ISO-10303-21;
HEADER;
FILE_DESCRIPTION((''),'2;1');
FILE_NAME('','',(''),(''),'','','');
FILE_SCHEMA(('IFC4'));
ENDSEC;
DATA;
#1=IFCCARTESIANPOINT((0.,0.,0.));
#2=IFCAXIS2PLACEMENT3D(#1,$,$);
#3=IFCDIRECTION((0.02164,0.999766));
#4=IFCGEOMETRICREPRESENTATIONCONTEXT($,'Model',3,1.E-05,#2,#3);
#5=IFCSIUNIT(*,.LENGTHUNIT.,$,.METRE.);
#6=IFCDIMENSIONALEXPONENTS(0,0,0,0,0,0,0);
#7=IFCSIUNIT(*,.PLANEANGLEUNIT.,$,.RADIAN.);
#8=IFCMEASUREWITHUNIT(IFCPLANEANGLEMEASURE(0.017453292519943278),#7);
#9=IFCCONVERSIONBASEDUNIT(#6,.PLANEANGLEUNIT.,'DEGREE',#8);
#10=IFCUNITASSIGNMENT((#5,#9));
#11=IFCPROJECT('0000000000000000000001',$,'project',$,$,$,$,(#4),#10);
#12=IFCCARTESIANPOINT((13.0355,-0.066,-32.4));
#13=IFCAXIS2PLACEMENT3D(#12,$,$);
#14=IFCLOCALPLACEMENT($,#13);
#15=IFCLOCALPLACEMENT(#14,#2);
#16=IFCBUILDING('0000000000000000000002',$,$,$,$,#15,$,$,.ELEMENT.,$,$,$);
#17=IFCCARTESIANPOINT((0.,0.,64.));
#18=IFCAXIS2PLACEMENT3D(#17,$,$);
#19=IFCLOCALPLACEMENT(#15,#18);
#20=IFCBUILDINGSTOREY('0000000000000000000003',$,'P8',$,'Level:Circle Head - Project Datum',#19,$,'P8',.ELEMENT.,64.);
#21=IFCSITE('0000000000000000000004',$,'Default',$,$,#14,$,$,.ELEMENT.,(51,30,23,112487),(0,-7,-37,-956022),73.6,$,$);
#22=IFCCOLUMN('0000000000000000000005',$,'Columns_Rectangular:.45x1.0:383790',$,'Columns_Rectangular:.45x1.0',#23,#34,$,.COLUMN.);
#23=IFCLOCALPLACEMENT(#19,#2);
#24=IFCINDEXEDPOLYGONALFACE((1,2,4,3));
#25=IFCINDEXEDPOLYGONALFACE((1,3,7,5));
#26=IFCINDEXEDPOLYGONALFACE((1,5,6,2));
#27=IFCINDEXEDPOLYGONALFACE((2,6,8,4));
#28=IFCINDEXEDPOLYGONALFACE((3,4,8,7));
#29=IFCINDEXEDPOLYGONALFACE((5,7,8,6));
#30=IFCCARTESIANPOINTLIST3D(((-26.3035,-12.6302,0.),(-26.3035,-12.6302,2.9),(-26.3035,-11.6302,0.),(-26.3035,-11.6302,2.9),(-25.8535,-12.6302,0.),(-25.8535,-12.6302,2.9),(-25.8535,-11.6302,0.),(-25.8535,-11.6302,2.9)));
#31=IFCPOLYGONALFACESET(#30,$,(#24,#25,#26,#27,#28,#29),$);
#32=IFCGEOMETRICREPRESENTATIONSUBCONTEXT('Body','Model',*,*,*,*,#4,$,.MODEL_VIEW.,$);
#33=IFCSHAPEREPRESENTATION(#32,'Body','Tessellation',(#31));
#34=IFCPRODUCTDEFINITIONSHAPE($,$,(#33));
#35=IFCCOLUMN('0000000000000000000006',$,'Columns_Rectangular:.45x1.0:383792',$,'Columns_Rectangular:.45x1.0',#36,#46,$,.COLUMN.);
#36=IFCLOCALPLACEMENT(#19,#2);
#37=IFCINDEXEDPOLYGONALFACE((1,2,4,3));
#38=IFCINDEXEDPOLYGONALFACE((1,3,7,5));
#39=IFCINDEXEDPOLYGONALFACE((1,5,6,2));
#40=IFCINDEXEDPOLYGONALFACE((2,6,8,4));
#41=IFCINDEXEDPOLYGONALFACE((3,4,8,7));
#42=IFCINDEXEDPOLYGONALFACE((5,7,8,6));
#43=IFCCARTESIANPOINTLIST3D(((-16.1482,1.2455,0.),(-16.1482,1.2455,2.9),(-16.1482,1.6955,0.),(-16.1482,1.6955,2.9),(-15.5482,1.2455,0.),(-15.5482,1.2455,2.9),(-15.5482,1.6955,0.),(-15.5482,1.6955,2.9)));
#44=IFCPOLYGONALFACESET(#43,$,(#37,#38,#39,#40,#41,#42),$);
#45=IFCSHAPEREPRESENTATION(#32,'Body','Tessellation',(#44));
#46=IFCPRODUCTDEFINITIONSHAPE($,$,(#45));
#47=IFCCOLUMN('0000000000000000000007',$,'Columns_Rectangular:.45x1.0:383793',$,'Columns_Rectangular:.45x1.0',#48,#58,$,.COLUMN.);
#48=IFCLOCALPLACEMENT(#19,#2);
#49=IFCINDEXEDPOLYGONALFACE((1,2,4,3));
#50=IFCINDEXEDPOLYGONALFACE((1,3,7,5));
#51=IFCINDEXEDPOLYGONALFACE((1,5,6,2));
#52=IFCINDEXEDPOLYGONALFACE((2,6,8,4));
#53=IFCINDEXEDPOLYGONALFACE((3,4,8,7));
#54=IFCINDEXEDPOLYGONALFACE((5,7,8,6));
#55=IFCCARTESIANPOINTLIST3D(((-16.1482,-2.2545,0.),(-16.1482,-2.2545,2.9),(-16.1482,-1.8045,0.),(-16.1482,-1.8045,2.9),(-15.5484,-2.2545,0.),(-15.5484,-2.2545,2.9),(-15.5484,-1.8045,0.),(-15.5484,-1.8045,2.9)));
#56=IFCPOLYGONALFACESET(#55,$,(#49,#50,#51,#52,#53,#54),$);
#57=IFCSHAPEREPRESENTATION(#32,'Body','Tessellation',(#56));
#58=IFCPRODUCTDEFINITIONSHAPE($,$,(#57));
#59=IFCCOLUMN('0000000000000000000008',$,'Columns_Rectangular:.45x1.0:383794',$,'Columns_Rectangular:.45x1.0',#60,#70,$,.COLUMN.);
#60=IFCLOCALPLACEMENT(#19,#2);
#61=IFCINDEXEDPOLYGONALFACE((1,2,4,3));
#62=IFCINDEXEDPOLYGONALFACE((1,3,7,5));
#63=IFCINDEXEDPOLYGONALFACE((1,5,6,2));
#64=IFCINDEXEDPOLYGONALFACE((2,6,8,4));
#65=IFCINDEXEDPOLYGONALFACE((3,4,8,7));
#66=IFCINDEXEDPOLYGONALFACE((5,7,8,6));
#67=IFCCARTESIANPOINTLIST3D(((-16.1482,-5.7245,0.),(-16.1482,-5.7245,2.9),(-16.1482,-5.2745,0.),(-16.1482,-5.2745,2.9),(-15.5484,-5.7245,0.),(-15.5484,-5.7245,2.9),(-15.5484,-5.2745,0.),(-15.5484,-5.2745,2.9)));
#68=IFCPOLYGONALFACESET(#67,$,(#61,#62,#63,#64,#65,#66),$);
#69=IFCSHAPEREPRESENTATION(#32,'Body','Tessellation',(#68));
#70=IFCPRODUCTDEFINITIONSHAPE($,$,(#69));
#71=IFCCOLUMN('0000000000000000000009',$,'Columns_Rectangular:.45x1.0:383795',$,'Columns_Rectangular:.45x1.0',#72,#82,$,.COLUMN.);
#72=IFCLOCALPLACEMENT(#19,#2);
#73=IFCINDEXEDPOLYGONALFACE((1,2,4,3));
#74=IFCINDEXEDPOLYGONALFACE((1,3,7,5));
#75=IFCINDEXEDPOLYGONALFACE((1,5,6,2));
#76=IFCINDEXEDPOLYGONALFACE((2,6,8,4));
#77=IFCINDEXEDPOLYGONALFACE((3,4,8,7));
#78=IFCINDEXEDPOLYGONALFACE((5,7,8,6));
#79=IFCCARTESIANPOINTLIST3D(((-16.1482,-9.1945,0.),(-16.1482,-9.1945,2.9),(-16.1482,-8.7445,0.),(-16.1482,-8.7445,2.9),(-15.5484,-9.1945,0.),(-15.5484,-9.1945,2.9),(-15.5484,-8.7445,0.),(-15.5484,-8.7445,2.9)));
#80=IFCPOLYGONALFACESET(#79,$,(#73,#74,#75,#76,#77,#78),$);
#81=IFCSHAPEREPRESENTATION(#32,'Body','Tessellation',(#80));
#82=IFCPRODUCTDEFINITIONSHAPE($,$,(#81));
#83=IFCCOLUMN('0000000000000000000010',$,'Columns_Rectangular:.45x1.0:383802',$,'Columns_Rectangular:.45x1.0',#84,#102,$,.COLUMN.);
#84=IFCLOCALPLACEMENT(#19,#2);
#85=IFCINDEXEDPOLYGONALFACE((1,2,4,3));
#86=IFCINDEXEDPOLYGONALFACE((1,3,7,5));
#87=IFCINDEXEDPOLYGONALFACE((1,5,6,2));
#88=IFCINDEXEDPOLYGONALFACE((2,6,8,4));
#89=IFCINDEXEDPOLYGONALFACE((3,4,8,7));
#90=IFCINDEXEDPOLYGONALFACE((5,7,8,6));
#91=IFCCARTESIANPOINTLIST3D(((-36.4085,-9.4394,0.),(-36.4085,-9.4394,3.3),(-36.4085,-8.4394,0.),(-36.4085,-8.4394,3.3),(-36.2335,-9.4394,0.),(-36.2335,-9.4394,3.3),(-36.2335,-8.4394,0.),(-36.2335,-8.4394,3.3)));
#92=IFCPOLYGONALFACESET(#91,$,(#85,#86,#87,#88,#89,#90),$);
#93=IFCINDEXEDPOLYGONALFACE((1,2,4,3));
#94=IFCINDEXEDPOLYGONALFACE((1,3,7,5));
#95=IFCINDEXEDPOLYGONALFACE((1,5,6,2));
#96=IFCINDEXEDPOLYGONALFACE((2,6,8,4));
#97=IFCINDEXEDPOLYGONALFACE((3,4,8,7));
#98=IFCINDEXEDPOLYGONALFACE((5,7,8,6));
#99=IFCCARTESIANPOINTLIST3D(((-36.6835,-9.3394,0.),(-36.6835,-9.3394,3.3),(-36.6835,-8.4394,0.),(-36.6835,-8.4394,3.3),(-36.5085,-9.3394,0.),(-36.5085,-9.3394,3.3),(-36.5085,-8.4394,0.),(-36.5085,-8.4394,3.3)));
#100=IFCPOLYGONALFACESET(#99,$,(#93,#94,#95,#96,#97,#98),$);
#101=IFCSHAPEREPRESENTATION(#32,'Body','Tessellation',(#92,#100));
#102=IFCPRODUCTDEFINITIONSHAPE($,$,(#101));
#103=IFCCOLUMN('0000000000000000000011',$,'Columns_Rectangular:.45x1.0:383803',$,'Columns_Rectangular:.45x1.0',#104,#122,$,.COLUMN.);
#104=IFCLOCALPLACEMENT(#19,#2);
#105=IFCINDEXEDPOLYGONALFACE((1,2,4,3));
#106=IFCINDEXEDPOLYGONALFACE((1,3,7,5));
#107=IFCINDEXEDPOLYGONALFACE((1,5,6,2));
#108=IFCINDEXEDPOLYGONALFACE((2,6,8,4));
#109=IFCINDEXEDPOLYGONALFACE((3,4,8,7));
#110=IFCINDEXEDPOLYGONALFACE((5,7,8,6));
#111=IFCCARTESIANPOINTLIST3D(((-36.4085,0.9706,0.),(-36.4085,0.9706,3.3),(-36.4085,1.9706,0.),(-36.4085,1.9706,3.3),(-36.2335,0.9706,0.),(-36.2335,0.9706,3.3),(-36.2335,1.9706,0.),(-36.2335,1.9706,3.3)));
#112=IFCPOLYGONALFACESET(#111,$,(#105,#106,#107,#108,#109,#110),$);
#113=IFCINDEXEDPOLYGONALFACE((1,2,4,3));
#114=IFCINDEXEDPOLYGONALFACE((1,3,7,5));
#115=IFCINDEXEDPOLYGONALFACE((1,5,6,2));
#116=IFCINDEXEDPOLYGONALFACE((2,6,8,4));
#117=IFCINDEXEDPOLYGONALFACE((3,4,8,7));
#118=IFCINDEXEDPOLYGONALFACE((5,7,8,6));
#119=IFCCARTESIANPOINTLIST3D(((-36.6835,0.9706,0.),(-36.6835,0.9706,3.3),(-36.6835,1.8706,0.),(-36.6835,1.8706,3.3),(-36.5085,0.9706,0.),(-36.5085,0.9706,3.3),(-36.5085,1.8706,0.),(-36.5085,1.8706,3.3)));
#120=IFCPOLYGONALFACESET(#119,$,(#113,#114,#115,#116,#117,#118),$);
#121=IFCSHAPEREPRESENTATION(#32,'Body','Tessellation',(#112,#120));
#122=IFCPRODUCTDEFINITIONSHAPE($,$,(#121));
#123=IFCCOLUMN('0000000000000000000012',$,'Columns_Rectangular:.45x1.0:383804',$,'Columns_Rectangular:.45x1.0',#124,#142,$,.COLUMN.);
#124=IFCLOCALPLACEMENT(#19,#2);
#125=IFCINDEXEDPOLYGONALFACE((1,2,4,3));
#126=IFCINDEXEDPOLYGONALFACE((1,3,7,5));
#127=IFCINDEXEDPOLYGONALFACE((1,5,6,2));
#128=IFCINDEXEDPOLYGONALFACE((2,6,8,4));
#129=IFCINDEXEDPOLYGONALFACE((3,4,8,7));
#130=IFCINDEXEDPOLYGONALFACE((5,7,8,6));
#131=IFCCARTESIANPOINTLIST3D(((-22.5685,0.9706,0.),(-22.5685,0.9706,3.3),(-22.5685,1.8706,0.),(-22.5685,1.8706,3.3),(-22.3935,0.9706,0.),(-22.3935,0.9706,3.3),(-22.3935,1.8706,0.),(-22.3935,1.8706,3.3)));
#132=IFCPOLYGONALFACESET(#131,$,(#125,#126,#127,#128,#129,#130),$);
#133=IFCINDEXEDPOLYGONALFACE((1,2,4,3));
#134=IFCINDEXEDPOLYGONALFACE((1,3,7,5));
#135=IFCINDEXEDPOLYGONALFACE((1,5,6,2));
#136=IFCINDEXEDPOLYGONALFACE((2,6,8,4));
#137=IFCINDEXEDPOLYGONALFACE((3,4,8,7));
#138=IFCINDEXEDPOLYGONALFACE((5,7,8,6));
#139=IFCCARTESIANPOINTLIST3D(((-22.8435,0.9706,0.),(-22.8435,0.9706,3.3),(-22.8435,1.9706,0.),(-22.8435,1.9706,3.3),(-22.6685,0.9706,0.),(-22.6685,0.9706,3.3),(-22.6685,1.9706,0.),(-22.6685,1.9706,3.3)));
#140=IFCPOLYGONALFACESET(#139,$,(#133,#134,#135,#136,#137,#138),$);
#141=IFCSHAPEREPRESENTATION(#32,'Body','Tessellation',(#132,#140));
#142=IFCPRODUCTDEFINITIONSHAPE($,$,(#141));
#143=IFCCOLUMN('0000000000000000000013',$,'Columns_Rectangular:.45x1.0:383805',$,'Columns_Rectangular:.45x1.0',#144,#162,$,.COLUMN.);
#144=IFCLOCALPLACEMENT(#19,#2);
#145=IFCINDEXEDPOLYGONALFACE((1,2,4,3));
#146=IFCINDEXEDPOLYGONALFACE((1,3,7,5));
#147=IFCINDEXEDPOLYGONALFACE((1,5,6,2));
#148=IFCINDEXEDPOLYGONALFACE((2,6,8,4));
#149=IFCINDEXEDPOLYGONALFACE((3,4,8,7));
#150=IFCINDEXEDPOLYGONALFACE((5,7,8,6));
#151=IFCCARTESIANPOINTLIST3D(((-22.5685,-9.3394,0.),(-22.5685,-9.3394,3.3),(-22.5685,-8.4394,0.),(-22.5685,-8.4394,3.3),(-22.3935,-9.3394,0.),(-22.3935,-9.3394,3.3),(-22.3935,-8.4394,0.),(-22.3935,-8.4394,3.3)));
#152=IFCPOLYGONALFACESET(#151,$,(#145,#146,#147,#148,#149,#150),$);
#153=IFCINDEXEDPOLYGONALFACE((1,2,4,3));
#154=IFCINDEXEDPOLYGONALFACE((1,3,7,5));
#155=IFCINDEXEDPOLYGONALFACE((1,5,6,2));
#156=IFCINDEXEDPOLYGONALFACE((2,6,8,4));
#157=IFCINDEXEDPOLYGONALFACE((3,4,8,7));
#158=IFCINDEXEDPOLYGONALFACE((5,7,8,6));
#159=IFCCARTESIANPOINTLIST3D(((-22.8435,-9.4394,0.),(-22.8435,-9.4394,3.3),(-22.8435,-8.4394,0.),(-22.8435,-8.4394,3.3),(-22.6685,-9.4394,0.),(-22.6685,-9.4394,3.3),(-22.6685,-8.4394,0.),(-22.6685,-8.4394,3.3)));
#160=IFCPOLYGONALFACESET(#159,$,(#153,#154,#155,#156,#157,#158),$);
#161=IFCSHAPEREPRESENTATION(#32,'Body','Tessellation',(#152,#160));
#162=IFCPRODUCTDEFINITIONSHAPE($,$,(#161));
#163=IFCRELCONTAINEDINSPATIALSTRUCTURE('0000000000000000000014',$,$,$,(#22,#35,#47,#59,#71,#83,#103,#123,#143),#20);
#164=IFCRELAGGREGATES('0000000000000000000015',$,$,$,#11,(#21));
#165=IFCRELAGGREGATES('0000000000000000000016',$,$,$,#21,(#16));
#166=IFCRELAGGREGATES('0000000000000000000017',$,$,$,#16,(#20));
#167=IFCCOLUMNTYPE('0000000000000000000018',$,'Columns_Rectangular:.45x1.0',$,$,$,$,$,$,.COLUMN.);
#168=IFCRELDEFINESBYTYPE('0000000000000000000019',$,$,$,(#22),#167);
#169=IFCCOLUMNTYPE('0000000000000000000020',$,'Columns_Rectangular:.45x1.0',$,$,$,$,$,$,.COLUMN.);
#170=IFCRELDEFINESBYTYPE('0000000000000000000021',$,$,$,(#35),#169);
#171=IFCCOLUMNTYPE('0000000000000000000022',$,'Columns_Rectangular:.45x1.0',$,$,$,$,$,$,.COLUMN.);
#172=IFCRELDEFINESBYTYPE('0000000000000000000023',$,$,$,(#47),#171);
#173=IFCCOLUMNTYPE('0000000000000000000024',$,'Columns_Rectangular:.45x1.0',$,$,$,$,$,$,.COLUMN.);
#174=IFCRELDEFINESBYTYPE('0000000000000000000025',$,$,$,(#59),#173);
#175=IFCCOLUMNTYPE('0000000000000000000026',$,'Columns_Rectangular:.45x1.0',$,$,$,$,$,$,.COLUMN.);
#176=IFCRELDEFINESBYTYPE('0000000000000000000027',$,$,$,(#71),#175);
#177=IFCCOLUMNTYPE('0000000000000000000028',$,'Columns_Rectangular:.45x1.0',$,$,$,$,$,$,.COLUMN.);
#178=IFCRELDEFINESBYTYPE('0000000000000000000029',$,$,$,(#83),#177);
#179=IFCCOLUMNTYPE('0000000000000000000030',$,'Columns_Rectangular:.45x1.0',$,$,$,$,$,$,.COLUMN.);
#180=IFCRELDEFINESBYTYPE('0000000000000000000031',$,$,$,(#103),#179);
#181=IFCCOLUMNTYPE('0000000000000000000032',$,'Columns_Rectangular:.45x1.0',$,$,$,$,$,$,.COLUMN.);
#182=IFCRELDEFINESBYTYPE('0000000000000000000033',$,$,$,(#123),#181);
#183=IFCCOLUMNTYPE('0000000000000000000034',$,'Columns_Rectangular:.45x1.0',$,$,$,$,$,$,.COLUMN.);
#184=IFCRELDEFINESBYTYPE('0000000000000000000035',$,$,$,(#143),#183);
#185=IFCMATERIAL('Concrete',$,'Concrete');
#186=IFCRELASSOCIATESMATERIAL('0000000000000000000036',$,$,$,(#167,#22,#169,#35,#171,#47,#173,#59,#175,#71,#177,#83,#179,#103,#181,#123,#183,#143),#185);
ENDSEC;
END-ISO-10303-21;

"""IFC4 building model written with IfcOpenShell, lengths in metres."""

from ifc_helpers import new_model, entity, si_unit, converted_unit, direction, frame, origin, place, context, subcontext, project, spatial, indexed_curve, outline, extrude, source, transform, mapped, material, type_object, type_shapes, element, save


model = new_model("IFC4")

# Units and contexts
model_context = context("Model", 3, precision=1e-05, world=origin(), true_north=direction((0.02164, 0.999766)))
body_context = subcontext(model_context, "Body", "Model", "MODEL_VIEW")
ifc_project = project(units=[si_unit("LENGTHUNIT", "METRE"), converted_unit("PLANEANGLEUNIT", "DEGREE", entity("IfcPlaneAngleMeasure", 0.017453292519943278), si_unit("PLANEANGLEUNIT", "RADIAN"), dimensions=[0, 0, 0, 0, 0, 0, 0])], contexts=[model_context])

# Site, building, storey
site_placement = place(None, frame((13.0355, -0.066, -32.4)))
site = spatial("IfcSite", under=ifc_project, at=site_placement, Name="Default", CompositionType="ELEMENT", RefLatitude=(51, 30, 23, 112487), RefLongitude=(0, -7, -37, -956022), RefElevation=73.6)
building_placement = place(site_placement, origin())
building = spatial("IfcBuilding", under=site, at=building_placement, CompositionType="ELEMENT")
storey_placement = place(building_placement, frame((0.0, 0.0, 64.0)))
storey = spatial("IfcBuildingStorey", under=building, at=storey_placement, Name="P8", ObjectType="Level:Circle Head - Project Datum", LongName="P8", CompositionType="ELEMENT", Elevation=64.0)

# Columns
ifc_material = material(Name="Concrete", Category="Concrete")
column_type_1 = type_object("IfcColumnType", Name="Columns_Rectangular:.45x1.0", PredefinedType="COLUMN", material=ifc_material)
shared_shape_1 = source(origin(), body_context, "Body", "SweptSolid", [
    extrude(outline(indexed_curve([(-0.5, -0.225), (0.5, -0.225), (0.5, 0.225), (-0.5, 0.225), (-0.5, -0.225)], self_intersect=False)), frame((-26.0785, -12.1302, 64.0), z_axis=(0.0, 0.0, 1.0), x_axis=(0.000011, 1.0, 0.0)), (0.0, 0.0, 1.0), 2.9),
])
type_shapes(column_type_1, [shared_shape_1])
column_1_placement = place(storey_placement, frame((0.0, 0.0, -64.0)))
element("IfcColumn", 1, at=column_1_placement, inside=storey, type_object=column_type_1, material=ifc_material, Name="Columns_Rectangular:.45x1.0:383790", ObjectType="Columns_Rectangular:.45x1.0", PredefinedType="COLUMN", context=body_context, shape_type="MappedRepresentation", body=[
    mapped(shared_shape_1, transform((0.0, 0.0, 0.0), scale=1.0)),
])
column_type_2 = type_object("IfcColumnType", Name="Columns_Rectangular:.45x1.0", PredefinedType="COLUMN", material=ifc_material)
shared_shape_2 = source(origin(), body_context, "Body", "SweptSolid", [
    extrude(outline(indexed_curve([(-0.3, -0.225), (0.3, -0.225), (0.3, 0.225), (-0.3, 0.225), (-0.3, -0.225)], self_intersect=False)), frame((-15.8482, 1.4705, 64.0), z_axis=(0.0, 0.0, 1.0), x_axis=(-1.0, 0.0, 0.0)), (0.0, 0.0, 1.0), 2.9),
])
type_shapes(column_type_2, [shared_shape_2])
column_2_placement = place(storey_placement, frame((0.0, 0.0, -64.0)))
element("IfcColumn", 2, at=column_2_placement, inside=storey, type_object=column_type_2, material=ifc_material, Name="Columns_Rectangular:.45x1.0:383792", ObjectType="Columns_Rectangular:.45x1.0", PredefinedType="COLUMN", context=body_context, shape_type="MappedRepresentation", body=[
    mapped(shared_shape_2, transform((0.0, 0.0, 0.0), scale=1.0)),
])
column_type_3 = type_object("IfcColumnType", Name="Columns_Rectangular:.45x1.0", PredefinedType="COLUMN", material=ifc_material)
shared_shape_3 = source(origin(), body_context, "Body", "SweptSolid", [
    extrude(outline(indexed_curve([(-0.2999, -0.225), (0.2999, -0.225), (0.2999, 0.225), (-0.2999, 0.225), (-0.2999, -0.225)], self_intersect=False)), frame((-15.8483, -2.0295, 64.0), z_axis=(0.0, 0.0, 1.0), x_axis=(-1.0, 0.0, 0.0)), (0.0, 0.0, 1.0), 2.9),
])
type_shapes(column_type_3, [shared_shape_3])
column_3_placement = place(storey_placement, frame((0.0, 0.0, -64.0)))
element("IfcColumn", 3, at=column_3_placement, inside=storey, type_object=column_type_3, material=ifc_material, Name="Columns_Rectangular:.45x1.0:383793", ObjectType="Columns_Rectangular:.45x1.0", PredefinedType="COLUMN", context=body_context, shape_type="MappedRepresentation", body=[
    mapped(shared_shape_3, transform((0.0, 0.0, 0.0), scale=1.0)),
])
column_type_4 = type_object("IfcColumnType", Name="Columns_Rectangular:.45x1.0", PredefinedType="COLUMN", material=ifc_material)
shared_shape_4 = source(origin(), body_context, "Body", "SweptSolid", [
    extrude(outline(indexed_curve([(-0.2999, -0.225), (0.2999, -0.225), (0.2999, 0.225), (-0.2999, 0.225), (-0.2999, -0.225)], self_intersect=False)), frame((-15.8483, -5.4995, 64.0), z_axis=(0.0, 0.0, 1.0), x_axis=(-1.0, 0.0, 0.0)), (0.0, 0.0, 1.0), 2.9),
])
type_shapes(column_type_4, [shared_shape_4])
column_4_placement = place(storey_placement, frame((0.0, 0.0, -64.0)))
element("IfcColumn", 4, at=column_4_placement, inside=storey, type_object=column_type_4, material=ifc_material, Name="Columns_Rectangular:.45x1.0:383794", ObjectType="Columns_Rectangular:.45x1.0", PredefinedType="COLUMN", context=body_context, shape_type="MappedRepresentation", body=[
    mapped(shared_shape_4, transform((0.0, 0.0, 0.0), scale=1.0)),
])
column_type_5 = type_object("IfcColumnType", Name="Columns_Rectangular:.45x1.0", PredefinedType="COLUMN", material=ifc_material)
shared_shape_5 = source(origin(), body_context, "Body", "SweptSolid", [
    extrude(outline(indexed_curve([(-0.2999, -0.225), (0.2999, -0.225), (0.2999, 0.225), (-0.2999, 0.225), (-0.2999, -0.225)], self_intersect=False)), frame((-15.8483, -8.9695, 64.0), z_axis=(0.0, 0.0, 1.0), x_axis=(-1.0, 0.0, 0.0)), (0.0, 0.0, 1.0), 2.9),
])
type_shapes(column_type_5, [shared_shape_5])
column_5_placement = place(storey_placement, frame((0.0, 0.0, -64.0)))
element("IfcColumn", 5, at=column_5_placement, inside=storey, type_object=column_type_5, material=ifc_material, Name="Columns_Rectangular:.45x1.0:383795", ObjectType="Columns_Rectangular:.45x1.0", PredefinedType="COLUMN", context=body_context, shape_type="MappedRepresentation", body=[
    mapped(shared_shape_5, transform((0.0, 0.0, 0.0), scale=1.0)),
])
column_type_6 = type_object("IfcColumnType", Name="Columns_Rectangular:.45x1.0", PredefinedType="COLUMN", material=ifc_material)
shared_shape_6 = source(origin(), body_context, "Body", "SweptSolid", [
    extrude(outline(indexed_curve([(-0.0875, -0.5), (0.0875, -0.5), (0.0875, 0.5), (-0.0875, 0.5), (-0.0875, -0.5)], self_intersect=False)), frame((-36.321, -8.9394, 64.0), z_axis=(0.0, 0.0, 1.0), x_axis=(-1.0, 0.0, 0.0)), (0.0, 0.0, 1.0), 3.3),
    extrude(outline(indexed_curve([(-0.45, -0.0875), (0.45, -0.0875), (0.45, 0.0875), (-0.45, 0.0875), (-0.45, -0.0875)], self_intersect=False)), frame((-36.596, -8.8894, 64.0), z_axis=(0.0, 0.0, 1.0), x_axis=(0.0, -1.0, 0.0)), (0.0, 0.0, 1.0), 3.3),
])
type_shapes(column_type_6, [shared_shape_6])
column_6_placement = place(storey_placement, frame((0.0, 0.0, -64.0)))
element("IfcColumn", 6, at=column_6_placement, inside=storey, type_object=column_type_6, material=ifc_material, Name="Columns_Rectangular:.45x1.0:383802", ObjectType="Columns_Rectangular:.45x1.0", PredefinedType="COLUMN", context=body_context, shape_type="MappedRepresentation", body=[
    mapped(shared_shape_6, transform((0.0, 0.0, 0.0), scale=1.0)),
])
column_type_7 = type_object("IfcColumnType", Name="Columns_Rectangular:.45x1.0", PredefinedType="COLUMN", material=ifc_material)
shared_shape_7 = source(origin(), body_context, "Body", "SweptSolid", [
    extrude(outline(indexed_curve([(-0.0875, -0.5), (0.0875, -0.5), (0.0875, 0.5), (-0.0875, 0.5), (-0.0875, -0.5)], self_intersect=False)), frame((-36.321, 1.4706, 64.0), z_axis=(0.0, 0.0, 1.0), x_axis=(-1.0, 0.0, 0.0)), (0.0, 0.0, 1.0), 3.3),
    extrude(outline(indexed_curve([(-0.45, -0.0875), (0.45, -0.0875), (0.45, 0.0875), (-0.45, 0.0875), (-0.45, -0.0875)], self_intersect=False)), frame((-36.596, 1.4206, 64.0), z_axis=(0.0, 0.0, 1.0), x_axis=(0.0, 1.0, 0.0)), (0.0, 0.0, 1.0), 3.3),
])
type_shapes(column_type_7, [shared_shape_7])
column_7_placement = place(storey_placement, frame((0.0, 0.0, -64.0)))
element("IfcColumn", 7, at=column_7_placement, inside=storey, type_object=column_type_7, material=ifc_material, Name="Columns_Rectangular:.45x1.0:383803", ObjectType="Columns_Rectangular:.45x1.0", PredefinedType="COLUMN", context=body_context, shape_type="MappedRepresentation", body=[
    mapped(shared_shape_7, transform((0.0, 0.0, 0.0), scale=1.0)),
])
column_type_8 = type_object("IfcColumnType", Name="Columns_Rectangular:.45x1.0", PredefinedType="COLUMN", material=ifc_material)
shared_shape_8 = source(origin(), body_context, "Body", "SweptSolid", [
    extrude(outline(indexed_curve([(-0.45, -0.0875), (0.45, -0.0875), (0.45, 0.0875), (-0.45, 0.0875), (-0.45, -0.0875)], self_intersect=False)), frame((-22.481, 1.4206, 64.0), z_axis=(0.0, 0.0, 1.0), x_axis=(0.0, 1.0, 0.0)), (0.0, 0.0, 1.0), 3.3),
    extrude(outline(indexed_curve([(-0.0875, -0.5), (0.0875, -0.5), (0.0875, 0.5), (-0.0875, 0.5), (-0.0875, -0.5)], self_intersect=False)), frame((-22.756, 1.4706, 64.0)), (0.0, 0.0, 1.0), 3.3),
])
type_shapes(column_type_8, [shared_shape_8])
column_8_placement = place(storey_placement, frame((0.0, 0.0, -64.0)))
element("IfcColumn", 8, at=column_8_placement, inside=storey, type_object=column_type_8, material=ifc_material, Name="Columns_Rectangular:.45x1.0:383804", ObjectType="Columns_Rectangular:.45x1.0", PredefinedType="COLUMN", context=body_context, shape_type="MappedRepresentation", body=[
    mapped(shared_shape_8, transform((0.0, 0.0, 0.0), scale=1.0)),
])
column_type_9 = type_object("IfcColumnType", Name="Columns_Rectangular:.45x1.0", PredefinedType="COLUMN", material=ifc_material)
shared_shape_9 = source(origin(), body_context, "Body", "SweptSolid", [
    extrude(outline(indexed_curve([(-0.45, -0.0875), (0.45, -0.0875), (0.45, 0.0875), (-0.45, 0.0875), (-0.45, -0.0875)], self_intersect=False)), frame((-22.481, -8.8894, 64.0), z_axis=(0.0, 0.0, 1.0), x_axis=(0.0, -1.0, 0.0)), (0.0, 0.0, 1.0), 3.3),
    extrude(outline(indexed_curve([(-0.0875, -0.5), (0.0875, -0.5), (0.0875, 0.5), (-0.0875, 0.5), (-0.0875, -0.5)], self_intersect=False)), frame((-22.756, -8.9394, 64.0)), (0.0, 0.0, 1.0), 3.3),
])
type_shapes(column_type_9, [shared_shape_9])
column_9_placement = place(storey_placement, frame((0.0, 0.0, -64.0)))
element("IfcColumn", 9, at=column_9_placement, inside=storey, type_object=column_type_9, material=ifc_material, Name="Columns_Rectangular:.45x1.0:383805", ObjectType="Columns_Rectangular:.45x1.0", PredefinedType="COLUMN", context=body_context, shape_type="MappedRepresentation", body=[
    mapped(shared_shape_9, transform((0.0, 0.0, 0.0), scale=1.0)),
])

save(model, "model.ifc")
